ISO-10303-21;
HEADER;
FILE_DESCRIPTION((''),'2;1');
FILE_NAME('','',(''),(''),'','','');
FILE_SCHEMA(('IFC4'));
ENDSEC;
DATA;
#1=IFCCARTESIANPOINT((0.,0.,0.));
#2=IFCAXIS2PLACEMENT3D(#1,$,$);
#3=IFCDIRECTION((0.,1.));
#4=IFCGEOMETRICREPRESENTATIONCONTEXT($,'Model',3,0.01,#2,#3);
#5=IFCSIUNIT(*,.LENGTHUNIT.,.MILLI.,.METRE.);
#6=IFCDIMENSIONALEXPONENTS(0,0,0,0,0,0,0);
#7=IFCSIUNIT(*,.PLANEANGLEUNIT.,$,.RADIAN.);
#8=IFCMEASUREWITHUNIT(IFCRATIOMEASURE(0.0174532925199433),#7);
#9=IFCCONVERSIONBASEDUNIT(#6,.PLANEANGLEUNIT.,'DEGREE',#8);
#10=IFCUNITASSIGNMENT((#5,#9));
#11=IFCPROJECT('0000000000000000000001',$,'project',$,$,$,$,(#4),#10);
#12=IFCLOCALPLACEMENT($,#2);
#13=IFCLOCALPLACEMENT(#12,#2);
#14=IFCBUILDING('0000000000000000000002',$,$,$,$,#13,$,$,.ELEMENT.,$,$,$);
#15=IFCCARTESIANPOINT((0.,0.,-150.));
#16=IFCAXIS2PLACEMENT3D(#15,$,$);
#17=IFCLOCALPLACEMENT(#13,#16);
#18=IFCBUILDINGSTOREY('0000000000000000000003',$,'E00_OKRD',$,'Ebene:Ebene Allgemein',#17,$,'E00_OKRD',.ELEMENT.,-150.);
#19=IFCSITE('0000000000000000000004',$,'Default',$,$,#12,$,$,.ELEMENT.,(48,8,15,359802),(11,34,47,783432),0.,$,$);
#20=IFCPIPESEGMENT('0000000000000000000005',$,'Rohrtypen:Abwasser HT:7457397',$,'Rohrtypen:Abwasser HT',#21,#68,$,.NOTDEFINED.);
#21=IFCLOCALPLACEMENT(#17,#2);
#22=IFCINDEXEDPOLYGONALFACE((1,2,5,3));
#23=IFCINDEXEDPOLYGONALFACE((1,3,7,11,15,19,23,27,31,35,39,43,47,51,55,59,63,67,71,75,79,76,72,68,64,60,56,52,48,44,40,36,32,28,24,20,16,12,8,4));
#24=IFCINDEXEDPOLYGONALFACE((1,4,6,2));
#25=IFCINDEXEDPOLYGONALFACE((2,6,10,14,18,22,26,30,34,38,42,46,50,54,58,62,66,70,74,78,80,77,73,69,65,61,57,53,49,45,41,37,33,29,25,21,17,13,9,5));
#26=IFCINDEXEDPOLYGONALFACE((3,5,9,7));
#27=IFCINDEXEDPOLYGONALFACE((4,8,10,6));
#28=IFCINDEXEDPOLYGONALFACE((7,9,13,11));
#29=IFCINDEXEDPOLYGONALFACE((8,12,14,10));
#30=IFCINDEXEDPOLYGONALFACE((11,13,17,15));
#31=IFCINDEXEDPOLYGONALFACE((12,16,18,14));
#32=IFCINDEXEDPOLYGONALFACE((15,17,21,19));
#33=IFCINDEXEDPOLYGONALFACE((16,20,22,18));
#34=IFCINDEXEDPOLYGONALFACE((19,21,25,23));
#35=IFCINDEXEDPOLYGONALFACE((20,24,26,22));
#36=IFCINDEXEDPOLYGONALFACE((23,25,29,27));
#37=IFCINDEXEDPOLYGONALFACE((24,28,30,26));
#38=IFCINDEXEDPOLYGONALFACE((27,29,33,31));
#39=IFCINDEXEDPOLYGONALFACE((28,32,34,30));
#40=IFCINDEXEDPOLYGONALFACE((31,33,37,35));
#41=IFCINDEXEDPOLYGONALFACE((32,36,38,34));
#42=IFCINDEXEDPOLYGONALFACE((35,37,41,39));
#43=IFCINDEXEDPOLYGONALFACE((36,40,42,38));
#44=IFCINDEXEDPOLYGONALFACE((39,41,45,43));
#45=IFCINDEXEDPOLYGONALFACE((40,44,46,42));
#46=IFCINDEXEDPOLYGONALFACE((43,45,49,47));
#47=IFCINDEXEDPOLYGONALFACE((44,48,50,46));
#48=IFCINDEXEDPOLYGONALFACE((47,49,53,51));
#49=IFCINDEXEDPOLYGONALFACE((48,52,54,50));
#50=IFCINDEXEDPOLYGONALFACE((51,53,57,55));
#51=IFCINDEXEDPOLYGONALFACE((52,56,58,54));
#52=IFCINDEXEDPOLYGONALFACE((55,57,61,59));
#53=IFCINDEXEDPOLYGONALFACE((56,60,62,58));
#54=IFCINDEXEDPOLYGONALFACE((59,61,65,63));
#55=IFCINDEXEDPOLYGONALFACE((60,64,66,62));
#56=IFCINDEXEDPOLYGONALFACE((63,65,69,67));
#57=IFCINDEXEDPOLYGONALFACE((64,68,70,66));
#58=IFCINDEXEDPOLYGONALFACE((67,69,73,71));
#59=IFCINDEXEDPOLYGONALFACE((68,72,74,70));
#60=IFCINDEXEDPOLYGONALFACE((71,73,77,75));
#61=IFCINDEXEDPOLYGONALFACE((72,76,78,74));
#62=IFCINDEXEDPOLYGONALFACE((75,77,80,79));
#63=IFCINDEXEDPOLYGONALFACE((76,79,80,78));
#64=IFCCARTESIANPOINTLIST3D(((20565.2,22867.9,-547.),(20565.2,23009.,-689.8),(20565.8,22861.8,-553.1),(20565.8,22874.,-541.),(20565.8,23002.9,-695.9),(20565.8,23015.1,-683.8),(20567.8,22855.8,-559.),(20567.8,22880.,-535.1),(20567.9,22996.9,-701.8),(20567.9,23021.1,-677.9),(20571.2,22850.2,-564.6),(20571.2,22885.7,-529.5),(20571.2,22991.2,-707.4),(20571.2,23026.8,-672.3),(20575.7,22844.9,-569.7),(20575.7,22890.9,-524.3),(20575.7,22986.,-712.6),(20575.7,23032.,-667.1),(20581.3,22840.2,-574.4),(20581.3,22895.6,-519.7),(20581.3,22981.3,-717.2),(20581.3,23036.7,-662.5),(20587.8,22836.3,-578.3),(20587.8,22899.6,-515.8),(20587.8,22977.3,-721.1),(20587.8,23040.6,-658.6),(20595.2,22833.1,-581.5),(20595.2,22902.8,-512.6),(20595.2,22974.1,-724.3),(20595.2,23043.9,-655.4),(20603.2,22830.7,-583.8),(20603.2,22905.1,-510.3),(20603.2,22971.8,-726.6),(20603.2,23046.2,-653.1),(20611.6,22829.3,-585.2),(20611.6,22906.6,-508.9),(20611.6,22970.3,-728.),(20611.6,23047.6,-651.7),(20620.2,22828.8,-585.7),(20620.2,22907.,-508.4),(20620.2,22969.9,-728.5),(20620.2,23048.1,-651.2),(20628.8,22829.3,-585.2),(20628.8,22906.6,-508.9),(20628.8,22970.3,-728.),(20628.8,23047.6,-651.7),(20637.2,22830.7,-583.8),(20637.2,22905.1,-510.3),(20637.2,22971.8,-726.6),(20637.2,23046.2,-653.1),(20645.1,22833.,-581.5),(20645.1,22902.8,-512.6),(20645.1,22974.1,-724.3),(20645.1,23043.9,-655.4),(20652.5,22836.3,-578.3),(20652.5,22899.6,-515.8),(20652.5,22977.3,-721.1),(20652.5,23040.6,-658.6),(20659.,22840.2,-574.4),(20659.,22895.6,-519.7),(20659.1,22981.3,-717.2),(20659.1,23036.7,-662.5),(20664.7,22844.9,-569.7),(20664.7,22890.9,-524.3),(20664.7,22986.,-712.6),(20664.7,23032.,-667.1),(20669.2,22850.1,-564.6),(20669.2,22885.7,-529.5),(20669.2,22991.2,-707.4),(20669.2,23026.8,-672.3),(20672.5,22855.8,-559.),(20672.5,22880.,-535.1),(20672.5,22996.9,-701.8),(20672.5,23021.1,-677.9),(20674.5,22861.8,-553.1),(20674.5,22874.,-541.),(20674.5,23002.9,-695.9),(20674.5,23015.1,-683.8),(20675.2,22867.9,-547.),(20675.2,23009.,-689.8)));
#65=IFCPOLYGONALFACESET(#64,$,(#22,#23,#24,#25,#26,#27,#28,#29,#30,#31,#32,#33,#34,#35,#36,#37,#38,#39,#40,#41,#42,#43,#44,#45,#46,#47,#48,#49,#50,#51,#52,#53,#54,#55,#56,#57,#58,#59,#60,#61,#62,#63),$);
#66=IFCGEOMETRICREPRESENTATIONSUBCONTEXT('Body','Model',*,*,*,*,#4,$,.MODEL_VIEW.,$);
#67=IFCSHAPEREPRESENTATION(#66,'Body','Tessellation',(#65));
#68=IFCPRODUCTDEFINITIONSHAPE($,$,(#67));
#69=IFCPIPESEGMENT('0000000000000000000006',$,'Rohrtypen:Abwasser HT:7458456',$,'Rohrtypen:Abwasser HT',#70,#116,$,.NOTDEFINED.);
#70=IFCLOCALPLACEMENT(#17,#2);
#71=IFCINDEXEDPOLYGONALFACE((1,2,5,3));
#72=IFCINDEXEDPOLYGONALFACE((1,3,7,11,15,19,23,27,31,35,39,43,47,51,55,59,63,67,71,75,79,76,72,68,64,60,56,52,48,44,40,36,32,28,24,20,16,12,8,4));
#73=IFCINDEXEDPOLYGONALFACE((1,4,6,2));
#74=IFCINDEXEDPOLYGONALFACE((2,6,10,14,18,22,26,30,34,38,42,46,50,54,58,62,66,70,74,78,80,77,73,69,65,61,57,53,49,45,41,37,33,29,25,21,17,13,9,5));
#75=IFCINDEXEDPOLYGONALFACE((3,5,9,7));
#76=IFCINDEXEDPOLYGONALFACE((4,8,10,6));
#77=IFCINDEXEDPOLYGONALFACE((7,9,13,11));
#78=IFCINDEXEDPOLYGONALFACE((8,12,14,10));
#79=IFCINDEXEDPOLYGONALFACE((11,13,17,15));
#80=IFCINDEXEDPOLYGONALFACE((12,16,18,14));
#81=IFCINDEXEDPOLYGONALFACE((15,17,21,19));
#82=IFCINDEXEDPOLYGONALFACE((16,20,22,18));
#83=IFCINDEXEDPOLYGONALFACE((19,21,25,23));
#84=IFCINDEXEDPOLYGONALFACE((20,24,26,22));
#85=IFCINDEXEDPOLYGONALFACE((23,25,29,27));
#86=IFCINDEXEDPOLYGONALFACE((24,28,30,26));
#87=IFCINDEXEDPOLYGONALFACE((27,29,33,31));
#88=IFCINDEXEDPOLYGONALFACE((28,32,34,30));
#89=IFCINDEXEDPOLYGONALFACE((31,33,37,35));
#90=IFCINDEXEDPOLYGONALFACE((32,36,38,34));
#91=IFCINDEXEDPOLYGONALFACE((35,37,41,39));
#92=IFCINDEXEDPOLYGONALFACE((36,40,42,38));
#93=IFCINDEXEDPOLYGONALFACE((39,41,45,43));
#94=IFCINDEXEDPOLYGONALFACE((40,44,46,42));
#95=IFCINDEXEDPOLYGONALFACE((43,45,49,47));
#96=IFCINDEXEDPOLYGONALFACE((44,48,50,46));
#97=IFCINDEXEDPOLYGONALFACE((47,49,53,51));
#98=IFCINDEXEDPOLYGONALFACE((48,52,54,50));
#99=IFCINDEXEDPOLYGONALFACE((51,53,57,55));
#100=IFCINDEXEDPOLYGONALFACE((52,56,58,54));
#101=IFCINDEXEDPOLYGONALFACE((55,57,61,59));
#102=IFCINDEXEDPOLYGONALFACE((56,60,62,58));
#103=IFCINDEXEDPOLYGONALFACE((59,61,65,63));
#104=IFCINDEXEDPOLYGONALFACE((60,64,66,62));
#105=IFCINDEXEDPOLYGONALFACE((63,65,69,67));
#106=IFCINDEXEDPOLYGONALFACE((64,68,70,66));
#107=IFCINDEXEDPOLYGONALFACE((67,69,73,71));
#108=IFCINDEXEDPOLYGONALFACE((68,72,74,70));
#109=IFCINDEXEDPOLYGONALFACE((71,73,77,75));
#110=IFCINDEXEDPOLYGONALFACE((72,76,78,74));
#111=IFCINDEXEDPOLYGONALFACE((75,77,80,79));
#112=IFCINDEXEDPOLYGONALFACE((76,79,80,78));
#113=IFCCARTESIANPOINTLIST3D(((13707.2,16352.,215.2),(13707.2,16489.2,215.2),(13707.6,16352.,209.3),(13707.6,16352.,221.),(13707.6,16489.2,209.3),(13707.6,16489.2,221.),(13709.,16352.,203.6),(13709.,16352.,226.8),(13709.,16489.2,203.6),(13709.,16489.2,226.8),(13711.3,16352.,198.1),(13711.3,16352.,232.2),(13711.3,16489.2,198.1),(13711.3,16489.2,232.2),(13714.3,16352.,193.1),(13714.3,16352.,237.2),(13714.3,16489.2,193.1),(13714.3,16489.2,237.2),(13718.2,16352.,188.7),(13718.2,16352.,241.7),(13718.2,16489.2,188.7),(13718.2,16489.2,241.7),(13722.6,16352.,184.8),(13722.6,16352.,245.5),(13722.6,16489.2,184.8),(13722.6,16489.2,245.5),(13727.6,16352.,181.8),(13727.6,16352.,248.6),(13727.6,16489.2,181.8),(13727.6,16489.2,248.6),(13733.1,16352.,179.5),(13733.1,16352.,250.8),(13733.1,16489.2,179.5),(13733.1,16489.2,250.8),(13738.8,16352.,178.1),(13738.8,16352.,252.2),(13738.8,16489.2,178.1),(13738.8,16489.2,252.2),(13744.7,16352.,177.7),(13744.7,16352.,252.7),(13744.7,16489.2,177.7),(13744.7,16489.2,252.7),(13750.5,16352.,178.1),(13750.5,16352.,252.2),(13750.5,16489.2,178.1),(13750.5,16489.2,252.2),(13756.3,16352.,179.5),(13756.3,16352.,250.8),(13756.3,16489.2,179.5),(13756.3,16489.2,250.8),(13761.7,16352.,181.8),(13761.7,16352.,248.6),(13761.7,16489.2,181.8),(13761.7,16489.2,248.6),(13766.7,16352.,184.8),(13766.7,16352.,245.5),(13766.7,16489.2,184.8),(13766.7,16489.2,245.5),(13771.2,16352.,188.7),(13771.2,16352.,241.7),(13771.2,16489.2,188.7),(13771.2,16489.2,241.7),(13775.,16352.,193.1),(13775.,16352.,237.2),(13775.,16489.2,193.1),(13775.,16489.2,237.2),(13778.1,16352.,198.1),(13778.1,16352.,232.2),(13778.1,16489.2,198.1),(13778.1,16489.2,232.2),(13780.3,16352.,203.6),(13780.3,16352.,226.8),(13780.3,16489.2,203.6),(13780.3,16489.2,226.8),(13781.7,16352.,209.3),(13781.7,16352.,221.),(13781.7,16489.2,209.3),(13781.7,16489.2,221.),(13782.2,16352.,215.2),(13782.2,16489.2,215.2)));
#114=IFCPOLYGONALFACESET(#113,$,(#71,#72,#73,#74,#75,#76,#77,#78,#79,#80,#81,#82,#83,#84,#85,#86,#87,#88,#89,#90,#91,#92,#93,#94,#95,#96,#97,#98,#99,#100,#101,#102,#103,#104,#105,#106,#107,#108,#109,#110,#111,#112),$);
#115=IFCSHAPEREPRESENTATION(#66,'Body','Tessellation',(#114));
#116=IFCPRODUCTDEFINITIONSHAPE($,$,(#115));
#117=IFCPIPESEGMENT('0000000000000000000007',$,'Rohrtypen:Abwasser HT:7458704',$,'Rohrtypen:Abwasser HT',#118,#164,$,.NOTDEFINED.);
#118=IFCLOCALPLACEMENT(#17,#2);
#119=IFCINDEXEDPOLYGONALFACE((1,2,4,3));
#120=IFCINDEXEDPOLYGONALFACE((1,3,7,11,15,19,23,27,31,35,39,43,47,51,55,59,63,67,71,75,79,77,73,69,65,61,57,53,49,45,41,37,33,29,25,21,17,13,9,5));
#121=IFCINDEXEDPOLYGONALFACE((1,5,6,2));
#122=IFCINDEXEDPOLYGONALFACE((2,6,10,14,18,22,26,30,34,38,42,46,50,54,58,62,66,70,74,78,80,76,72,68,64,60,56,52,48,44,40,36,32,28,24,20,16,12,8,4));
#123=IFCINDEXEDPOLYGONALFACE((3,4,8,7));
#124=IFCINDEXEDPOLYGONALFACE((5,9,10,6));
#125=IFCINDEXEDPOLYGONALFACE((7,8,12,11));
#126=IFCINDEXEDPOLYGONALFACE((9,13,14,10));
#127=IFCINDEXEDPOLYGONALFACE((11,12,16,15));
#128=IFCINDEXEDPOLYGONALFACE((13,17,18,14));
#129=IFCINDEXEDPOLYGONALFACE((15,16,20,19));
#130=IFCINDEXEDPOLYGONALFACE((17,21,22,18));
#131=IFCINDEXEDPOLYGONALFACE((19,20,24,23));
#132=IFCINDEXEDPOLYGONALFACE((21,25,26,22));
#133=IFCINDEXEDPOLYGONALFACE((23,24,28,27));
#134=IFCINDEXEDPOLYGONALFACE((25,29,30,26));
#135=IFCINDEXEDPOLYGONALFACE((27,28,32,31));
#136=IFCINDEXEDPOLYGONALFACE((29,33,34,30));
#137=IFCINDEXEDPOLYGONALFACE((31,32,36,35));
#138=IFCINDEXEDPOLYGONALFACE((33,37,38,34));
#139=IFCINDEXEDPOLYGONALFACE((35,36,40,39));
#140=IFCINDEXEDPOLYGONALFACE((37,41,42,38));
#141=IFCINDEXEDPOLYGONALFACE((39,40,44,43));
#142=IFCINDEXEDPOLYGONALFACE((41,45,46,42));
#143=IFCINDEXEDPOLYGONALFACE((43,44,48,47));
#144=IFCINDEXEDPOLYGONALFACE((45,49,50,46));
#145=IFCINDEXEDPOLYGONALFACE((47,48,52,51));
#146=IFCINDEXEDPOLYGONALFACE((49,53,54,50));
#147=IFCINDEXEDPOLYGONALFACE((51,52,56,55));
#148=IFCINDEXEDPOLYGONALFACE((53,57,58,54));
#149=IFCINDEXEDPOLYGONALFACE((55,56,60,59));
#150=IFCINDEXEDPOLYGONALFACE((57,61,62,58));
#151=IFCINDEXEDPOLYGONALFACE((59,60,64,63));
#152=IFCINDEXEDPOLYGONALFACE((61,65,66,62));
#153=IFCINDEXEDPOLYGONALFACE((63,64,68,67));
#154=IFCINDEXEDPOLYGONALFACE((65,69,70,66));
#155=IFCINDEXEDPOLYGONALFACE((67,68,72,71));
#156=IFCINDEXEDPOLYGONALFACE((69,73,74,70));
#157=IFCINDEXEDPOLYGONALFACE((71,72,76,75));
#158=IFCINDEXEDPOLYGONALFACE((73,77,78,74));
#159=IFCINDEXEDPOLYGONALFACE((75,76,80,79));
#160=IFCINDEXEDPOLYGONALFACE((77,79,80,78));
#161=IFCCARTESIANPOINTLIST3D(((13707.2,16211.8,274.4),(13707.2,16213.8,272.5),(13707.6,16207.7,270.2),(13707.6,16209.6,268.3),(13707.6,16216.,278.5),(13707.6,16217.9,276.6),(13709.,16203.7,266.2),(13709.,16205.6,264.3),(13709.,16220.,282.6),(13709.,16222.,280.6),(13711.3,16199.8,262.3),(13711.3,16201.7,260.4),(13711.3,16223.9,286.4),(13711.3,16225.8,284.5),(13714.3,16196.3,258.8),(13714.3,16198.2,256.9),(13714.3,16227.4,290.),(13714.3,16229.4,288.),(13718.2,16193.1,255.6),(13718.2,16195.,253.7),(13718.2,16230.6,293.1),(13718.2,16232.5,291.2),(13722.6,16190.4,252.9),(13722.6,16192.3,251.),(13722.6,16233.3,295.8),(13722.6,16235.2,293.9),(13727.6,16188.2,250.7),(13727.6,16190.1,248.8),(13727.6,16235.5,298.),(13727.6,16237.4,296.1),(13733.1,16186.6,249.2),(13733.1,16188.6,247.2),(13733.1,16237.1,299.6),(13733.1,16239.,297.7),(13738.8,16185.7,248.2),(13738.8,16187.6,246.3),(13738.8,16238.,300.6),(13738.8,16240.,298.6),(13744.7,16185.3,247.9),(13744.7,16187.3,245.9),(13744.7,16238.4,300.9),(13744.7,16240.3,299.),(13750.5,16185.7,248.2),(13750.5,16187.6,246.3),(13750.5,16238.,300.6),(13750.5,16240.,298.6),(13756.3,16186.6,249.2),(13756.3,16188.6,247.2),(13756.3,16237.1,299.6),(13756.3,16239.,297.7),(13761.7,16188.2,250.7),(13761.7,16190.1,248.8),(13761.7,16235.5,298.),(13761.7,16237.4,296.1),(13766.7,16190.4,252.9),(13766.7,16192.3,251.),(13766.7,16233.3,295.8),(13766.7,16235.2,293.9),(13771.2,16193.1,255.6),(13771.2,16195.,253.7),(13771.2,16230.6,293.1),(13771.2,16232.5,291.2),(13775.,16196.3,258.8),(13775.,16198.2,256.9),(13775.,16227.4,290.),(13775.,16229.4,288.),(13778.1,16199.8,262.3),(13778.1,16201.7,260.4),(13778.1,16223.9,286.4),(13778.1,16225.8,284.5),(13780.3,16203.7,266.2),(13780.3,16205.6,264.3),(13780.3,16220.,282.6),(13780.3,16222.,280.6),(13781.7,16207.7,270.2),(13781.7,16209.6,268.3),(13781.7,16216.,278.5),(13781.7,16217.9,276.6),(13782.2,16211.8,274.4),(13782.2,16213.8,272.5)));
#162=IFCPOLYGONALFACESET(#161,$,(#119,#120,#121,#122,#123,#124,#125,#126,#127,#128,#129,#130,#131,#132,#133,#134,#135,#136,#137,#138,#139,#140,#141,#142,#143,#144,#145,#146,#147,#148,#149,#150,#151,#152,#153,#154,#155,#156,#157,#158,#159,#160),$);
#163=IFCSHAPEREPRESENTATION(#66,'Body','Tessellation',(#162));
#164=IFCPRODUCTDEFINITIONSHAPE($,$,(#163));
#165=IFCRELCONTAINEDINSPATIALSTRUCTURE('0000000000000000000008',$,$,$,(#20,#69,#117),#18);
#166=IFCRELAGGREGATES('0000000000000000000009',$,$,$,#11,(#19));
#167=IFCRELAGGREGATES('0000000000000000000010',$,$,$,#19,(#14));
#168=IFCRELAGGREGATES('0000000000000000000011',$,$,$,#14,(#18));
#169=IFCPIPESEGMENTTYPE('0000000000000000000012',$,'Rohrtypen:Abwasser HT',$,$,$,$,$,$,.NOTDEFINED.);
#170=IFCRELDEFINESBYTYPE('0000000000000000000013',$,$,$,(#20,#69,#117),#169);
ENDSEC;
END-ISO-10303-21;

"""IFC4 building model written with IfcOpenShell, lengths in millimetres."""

from ifc_helpers import new_model, entity, si_unit, converted_unit, direction, frame, origin, place, context, subcontext, project, spatial, indexed_curve, outline, extrude, type_object, element, save


model = new_model("IFC4")

# Units and contexts
model_context = context("Model", 3, precision=0.01, world=origin(), true_north=direction((0.0, 1.0)))
body_context = subcontext(model_context, "Body", "Model", "MODEL_VIEW")
ifc_project = project(units=[si_unit("LENGTHUNIT", "METRE", prefix="MILLI"), converted_unit("PLANEANGLEUNIT", "DEGREE", entity("IfcRatioMeasure", 0.0174532925199433), si_unit("PLANEANGLEUNIT", "RADIAN"), dimensions=[0, 0, 0, 0, 0, 0, 0])], contexts=[model_context])

# Site, building, storey
site_placement = place(None, origin())
site = spatial("IfcSite", under=ifc_project, at=site_placement, Name="Default", CompositionType="ELEMENT", RefLatitude=(48, 8, 15, 359802), RefLongitude=(11, 34, 47, 783432), RefElevation=0.0)
building_placement = place(site_placement, origin())
building = spatial("IfcBuilding", under=site, at=building_placement, CompositionType="ELEMENT")
storey_placement = place(building_placement, frame((0.0, 0.0, -150.0)))
storey = spatial("IfcBuildingStorey", under=building, at=storey_placement, Name="E00_OKRD", ObjectType="Ebene:Ebene Allgemein", LongName="E00_OKRD", CompositionType="ELEMENT", Elevation=-150.0)

# Pipe segments
pipe_segment_type_1 = type_object("IfcPipeSegmentType", Name="Rohrtypen:Abwasser HT", PredefinedType="NOTDEFINED")
pipe_segment_1_placement = place(storey_placement, origin())
element("IfcPipeSegment", 1, at=pipe_segment_1_placement, inside=storey, type_object=pipe_segment_type_1, Name="Rohrtypen:Abwasser HT:7457397", ObjectType="Rohrtypen:Abwasser HT", PredefinedType="NOTDEFINED", context=body_context, shape_type="SweptSolid", body=[
    extrude(outline(indexed_curve([(55.0, 0.0), (54.3, 8.6), (52.3, 17.0), (49.0, 25.0), (44.5, 32.3), (38.9, 38.9), (32.3, 44.5), (25.0, 49.0), (17.0, 52.3), (8.6, 54.3), (0.0, 55.0), (-8.6, 54.3), (-17.0, 52.3), (-25.0, 49.0), (-32.3, 44.5), (-38.9, 38.9), (-44.5, 32.3), (-49.0, 25.0), (-52.3, 17.0), (-54.3, 8.6), (-55.0, 0.0), (-54.3, -8.6), (-52.3, -17.0), (-49.0, -25.0), (-44.5, -32.3), (-38.9, -38.9), (-32.3, -44.5), (-25.0, -49.0), (-17.0, -52.3), (-8.6, -54.3), (0.0, -55.0), (8.6, -54.3), (17.0, -52.3), (25.0, -49.0), (32.3, -44.5), (38.9, -38.9), (44.5, -32.3), (49.0, -25.0), (52.3, -17.0), (54.3, -8.6), (55.0, 0.0)], self_intersect=False)), frame((20620.2, 22867.9, -547.0), z_axis=(0.000019, 0.70277, -0.711417), x_axis=(-1.0, 0.000026, 0.0)), (0.0, 0.0, 1.0), 200.7),
])
pipe_segment_2_placement = place(storey_placement, origin())
element("IfcPipeSegment", 2, at=pipe_segment_2_placement, inside=storey, type_object=pipe_segment_type_1, Name="Rohrtypen:Abwasser HT:7458456", ObjectType="Rohrtypen:Abwasser HT", PredefinedType="NOTDEFINED", context=body_context, shape_type="SweptSolid", body=[
    extrude(outline(indexed_curve([(37.5, 0.0), (37.0, 5.9), (35.7, 11.6), (33.4, 17.0), (30.3, 22.0), (26.5, 26.5), (22.0, 30.3), (17.0, 33.4), (11.6, 35.7), (5.9, 37.0), (0.0, 37.5), (-5.9, 37.0), (-11.6, 35.7), (-17.0, 33.4), (-22.0, 30.3), (-26.5, 26.5), (-30.3, 22.0), (-33.4, 17.0), (-35.7, 11.6), (-37.0, 5.9), (-37.5, 0.0), (-37.0, -5.9), (-35.7, -11.6), (-33.4, -17.0), (-30.3, -22.0), (-26.5, -26.5), (-22.0, -30.3), (-17.0, -33.4), (-11.6, -35.7), (-5.9, -37.0), (0.0, -37.5), (5.9, -37.0), (11.6, -35.7), (17.0, -33.4), (22.0, -30.3), (26.5, -26.5), (30.3, -22.0), (33.4, -17.0), (35.7, -11.6), (37.0, -5.9), (37.5, 0.0)], self_intersect=False)), frame((13744.7, 16352.0, 215.2), z_axis=(0.0, 1.0, 0.0), x_axis=(-1.0, 0.0, 0.0)), (0.0, 0.0, 1.0), 137.2),
])
pipe_segment_3_placement = place(storey_placement, origin())
element("IfcPipeSegment", 3, at=pipe_segment_3_placement, inside=storey, type_object=pipe_segment_type_1, Name="Rohrtypen:Abwasser HT:7458704", ObjectType="Rohrtypen:Abwasser HT", PredefinedType="NOTDEFINED", context=body_context, shape_type="SweptSolid", body=[
    extrude(outline(indexed_curve([(37.5, 0.0), (37.0, 5.9), (35.7, 11.6), (33.4, 17.0), (30.3, 22.0), (26.5, 26.5), (22.0, 30.3), (17.0, 33.4), (11.6, 35.7), (5.9, 37.0), (0.0, 37.5), (-5.9, 37.0), (-11.6, 35.7), (-17.0, 33.4), (-22.0, 30.3), (-26.5, 26.5), (-30.3, 22.0), (-33.4, 17.0), (-35.7, 11.6), (-37.0, 5.9), (-37.5, 0.0), (-37.0, -5.9), (-35.7, -11.6), (-33.4, -17.0), (-30.3, -22.0), (-26.5, -26.5), (-22.0, -30.3), (-17.0, -33.4), (-11.6, -35.7), (-5.9, -37.0), (0.0, -37.5), (5.9, -37.0), (11.6, -35.7), (17.0, -33.4), (22.0, -30.3), (26.5, -26.5), (30.3, -22.0), (33.4, -17.0), (35.7, -11.6), (37.0, -5.9), (37.5, 0.0)], self_intersect=False)), frame((13744.7, 16211.8, 274.4), z_axis=(0.0, 0.707107, -0.707107), x_axis=(-1.0, 0.0, 0.0)), (0.0, 0.0, 1.0), 2.7),
])

save(model, "model.ifc")
